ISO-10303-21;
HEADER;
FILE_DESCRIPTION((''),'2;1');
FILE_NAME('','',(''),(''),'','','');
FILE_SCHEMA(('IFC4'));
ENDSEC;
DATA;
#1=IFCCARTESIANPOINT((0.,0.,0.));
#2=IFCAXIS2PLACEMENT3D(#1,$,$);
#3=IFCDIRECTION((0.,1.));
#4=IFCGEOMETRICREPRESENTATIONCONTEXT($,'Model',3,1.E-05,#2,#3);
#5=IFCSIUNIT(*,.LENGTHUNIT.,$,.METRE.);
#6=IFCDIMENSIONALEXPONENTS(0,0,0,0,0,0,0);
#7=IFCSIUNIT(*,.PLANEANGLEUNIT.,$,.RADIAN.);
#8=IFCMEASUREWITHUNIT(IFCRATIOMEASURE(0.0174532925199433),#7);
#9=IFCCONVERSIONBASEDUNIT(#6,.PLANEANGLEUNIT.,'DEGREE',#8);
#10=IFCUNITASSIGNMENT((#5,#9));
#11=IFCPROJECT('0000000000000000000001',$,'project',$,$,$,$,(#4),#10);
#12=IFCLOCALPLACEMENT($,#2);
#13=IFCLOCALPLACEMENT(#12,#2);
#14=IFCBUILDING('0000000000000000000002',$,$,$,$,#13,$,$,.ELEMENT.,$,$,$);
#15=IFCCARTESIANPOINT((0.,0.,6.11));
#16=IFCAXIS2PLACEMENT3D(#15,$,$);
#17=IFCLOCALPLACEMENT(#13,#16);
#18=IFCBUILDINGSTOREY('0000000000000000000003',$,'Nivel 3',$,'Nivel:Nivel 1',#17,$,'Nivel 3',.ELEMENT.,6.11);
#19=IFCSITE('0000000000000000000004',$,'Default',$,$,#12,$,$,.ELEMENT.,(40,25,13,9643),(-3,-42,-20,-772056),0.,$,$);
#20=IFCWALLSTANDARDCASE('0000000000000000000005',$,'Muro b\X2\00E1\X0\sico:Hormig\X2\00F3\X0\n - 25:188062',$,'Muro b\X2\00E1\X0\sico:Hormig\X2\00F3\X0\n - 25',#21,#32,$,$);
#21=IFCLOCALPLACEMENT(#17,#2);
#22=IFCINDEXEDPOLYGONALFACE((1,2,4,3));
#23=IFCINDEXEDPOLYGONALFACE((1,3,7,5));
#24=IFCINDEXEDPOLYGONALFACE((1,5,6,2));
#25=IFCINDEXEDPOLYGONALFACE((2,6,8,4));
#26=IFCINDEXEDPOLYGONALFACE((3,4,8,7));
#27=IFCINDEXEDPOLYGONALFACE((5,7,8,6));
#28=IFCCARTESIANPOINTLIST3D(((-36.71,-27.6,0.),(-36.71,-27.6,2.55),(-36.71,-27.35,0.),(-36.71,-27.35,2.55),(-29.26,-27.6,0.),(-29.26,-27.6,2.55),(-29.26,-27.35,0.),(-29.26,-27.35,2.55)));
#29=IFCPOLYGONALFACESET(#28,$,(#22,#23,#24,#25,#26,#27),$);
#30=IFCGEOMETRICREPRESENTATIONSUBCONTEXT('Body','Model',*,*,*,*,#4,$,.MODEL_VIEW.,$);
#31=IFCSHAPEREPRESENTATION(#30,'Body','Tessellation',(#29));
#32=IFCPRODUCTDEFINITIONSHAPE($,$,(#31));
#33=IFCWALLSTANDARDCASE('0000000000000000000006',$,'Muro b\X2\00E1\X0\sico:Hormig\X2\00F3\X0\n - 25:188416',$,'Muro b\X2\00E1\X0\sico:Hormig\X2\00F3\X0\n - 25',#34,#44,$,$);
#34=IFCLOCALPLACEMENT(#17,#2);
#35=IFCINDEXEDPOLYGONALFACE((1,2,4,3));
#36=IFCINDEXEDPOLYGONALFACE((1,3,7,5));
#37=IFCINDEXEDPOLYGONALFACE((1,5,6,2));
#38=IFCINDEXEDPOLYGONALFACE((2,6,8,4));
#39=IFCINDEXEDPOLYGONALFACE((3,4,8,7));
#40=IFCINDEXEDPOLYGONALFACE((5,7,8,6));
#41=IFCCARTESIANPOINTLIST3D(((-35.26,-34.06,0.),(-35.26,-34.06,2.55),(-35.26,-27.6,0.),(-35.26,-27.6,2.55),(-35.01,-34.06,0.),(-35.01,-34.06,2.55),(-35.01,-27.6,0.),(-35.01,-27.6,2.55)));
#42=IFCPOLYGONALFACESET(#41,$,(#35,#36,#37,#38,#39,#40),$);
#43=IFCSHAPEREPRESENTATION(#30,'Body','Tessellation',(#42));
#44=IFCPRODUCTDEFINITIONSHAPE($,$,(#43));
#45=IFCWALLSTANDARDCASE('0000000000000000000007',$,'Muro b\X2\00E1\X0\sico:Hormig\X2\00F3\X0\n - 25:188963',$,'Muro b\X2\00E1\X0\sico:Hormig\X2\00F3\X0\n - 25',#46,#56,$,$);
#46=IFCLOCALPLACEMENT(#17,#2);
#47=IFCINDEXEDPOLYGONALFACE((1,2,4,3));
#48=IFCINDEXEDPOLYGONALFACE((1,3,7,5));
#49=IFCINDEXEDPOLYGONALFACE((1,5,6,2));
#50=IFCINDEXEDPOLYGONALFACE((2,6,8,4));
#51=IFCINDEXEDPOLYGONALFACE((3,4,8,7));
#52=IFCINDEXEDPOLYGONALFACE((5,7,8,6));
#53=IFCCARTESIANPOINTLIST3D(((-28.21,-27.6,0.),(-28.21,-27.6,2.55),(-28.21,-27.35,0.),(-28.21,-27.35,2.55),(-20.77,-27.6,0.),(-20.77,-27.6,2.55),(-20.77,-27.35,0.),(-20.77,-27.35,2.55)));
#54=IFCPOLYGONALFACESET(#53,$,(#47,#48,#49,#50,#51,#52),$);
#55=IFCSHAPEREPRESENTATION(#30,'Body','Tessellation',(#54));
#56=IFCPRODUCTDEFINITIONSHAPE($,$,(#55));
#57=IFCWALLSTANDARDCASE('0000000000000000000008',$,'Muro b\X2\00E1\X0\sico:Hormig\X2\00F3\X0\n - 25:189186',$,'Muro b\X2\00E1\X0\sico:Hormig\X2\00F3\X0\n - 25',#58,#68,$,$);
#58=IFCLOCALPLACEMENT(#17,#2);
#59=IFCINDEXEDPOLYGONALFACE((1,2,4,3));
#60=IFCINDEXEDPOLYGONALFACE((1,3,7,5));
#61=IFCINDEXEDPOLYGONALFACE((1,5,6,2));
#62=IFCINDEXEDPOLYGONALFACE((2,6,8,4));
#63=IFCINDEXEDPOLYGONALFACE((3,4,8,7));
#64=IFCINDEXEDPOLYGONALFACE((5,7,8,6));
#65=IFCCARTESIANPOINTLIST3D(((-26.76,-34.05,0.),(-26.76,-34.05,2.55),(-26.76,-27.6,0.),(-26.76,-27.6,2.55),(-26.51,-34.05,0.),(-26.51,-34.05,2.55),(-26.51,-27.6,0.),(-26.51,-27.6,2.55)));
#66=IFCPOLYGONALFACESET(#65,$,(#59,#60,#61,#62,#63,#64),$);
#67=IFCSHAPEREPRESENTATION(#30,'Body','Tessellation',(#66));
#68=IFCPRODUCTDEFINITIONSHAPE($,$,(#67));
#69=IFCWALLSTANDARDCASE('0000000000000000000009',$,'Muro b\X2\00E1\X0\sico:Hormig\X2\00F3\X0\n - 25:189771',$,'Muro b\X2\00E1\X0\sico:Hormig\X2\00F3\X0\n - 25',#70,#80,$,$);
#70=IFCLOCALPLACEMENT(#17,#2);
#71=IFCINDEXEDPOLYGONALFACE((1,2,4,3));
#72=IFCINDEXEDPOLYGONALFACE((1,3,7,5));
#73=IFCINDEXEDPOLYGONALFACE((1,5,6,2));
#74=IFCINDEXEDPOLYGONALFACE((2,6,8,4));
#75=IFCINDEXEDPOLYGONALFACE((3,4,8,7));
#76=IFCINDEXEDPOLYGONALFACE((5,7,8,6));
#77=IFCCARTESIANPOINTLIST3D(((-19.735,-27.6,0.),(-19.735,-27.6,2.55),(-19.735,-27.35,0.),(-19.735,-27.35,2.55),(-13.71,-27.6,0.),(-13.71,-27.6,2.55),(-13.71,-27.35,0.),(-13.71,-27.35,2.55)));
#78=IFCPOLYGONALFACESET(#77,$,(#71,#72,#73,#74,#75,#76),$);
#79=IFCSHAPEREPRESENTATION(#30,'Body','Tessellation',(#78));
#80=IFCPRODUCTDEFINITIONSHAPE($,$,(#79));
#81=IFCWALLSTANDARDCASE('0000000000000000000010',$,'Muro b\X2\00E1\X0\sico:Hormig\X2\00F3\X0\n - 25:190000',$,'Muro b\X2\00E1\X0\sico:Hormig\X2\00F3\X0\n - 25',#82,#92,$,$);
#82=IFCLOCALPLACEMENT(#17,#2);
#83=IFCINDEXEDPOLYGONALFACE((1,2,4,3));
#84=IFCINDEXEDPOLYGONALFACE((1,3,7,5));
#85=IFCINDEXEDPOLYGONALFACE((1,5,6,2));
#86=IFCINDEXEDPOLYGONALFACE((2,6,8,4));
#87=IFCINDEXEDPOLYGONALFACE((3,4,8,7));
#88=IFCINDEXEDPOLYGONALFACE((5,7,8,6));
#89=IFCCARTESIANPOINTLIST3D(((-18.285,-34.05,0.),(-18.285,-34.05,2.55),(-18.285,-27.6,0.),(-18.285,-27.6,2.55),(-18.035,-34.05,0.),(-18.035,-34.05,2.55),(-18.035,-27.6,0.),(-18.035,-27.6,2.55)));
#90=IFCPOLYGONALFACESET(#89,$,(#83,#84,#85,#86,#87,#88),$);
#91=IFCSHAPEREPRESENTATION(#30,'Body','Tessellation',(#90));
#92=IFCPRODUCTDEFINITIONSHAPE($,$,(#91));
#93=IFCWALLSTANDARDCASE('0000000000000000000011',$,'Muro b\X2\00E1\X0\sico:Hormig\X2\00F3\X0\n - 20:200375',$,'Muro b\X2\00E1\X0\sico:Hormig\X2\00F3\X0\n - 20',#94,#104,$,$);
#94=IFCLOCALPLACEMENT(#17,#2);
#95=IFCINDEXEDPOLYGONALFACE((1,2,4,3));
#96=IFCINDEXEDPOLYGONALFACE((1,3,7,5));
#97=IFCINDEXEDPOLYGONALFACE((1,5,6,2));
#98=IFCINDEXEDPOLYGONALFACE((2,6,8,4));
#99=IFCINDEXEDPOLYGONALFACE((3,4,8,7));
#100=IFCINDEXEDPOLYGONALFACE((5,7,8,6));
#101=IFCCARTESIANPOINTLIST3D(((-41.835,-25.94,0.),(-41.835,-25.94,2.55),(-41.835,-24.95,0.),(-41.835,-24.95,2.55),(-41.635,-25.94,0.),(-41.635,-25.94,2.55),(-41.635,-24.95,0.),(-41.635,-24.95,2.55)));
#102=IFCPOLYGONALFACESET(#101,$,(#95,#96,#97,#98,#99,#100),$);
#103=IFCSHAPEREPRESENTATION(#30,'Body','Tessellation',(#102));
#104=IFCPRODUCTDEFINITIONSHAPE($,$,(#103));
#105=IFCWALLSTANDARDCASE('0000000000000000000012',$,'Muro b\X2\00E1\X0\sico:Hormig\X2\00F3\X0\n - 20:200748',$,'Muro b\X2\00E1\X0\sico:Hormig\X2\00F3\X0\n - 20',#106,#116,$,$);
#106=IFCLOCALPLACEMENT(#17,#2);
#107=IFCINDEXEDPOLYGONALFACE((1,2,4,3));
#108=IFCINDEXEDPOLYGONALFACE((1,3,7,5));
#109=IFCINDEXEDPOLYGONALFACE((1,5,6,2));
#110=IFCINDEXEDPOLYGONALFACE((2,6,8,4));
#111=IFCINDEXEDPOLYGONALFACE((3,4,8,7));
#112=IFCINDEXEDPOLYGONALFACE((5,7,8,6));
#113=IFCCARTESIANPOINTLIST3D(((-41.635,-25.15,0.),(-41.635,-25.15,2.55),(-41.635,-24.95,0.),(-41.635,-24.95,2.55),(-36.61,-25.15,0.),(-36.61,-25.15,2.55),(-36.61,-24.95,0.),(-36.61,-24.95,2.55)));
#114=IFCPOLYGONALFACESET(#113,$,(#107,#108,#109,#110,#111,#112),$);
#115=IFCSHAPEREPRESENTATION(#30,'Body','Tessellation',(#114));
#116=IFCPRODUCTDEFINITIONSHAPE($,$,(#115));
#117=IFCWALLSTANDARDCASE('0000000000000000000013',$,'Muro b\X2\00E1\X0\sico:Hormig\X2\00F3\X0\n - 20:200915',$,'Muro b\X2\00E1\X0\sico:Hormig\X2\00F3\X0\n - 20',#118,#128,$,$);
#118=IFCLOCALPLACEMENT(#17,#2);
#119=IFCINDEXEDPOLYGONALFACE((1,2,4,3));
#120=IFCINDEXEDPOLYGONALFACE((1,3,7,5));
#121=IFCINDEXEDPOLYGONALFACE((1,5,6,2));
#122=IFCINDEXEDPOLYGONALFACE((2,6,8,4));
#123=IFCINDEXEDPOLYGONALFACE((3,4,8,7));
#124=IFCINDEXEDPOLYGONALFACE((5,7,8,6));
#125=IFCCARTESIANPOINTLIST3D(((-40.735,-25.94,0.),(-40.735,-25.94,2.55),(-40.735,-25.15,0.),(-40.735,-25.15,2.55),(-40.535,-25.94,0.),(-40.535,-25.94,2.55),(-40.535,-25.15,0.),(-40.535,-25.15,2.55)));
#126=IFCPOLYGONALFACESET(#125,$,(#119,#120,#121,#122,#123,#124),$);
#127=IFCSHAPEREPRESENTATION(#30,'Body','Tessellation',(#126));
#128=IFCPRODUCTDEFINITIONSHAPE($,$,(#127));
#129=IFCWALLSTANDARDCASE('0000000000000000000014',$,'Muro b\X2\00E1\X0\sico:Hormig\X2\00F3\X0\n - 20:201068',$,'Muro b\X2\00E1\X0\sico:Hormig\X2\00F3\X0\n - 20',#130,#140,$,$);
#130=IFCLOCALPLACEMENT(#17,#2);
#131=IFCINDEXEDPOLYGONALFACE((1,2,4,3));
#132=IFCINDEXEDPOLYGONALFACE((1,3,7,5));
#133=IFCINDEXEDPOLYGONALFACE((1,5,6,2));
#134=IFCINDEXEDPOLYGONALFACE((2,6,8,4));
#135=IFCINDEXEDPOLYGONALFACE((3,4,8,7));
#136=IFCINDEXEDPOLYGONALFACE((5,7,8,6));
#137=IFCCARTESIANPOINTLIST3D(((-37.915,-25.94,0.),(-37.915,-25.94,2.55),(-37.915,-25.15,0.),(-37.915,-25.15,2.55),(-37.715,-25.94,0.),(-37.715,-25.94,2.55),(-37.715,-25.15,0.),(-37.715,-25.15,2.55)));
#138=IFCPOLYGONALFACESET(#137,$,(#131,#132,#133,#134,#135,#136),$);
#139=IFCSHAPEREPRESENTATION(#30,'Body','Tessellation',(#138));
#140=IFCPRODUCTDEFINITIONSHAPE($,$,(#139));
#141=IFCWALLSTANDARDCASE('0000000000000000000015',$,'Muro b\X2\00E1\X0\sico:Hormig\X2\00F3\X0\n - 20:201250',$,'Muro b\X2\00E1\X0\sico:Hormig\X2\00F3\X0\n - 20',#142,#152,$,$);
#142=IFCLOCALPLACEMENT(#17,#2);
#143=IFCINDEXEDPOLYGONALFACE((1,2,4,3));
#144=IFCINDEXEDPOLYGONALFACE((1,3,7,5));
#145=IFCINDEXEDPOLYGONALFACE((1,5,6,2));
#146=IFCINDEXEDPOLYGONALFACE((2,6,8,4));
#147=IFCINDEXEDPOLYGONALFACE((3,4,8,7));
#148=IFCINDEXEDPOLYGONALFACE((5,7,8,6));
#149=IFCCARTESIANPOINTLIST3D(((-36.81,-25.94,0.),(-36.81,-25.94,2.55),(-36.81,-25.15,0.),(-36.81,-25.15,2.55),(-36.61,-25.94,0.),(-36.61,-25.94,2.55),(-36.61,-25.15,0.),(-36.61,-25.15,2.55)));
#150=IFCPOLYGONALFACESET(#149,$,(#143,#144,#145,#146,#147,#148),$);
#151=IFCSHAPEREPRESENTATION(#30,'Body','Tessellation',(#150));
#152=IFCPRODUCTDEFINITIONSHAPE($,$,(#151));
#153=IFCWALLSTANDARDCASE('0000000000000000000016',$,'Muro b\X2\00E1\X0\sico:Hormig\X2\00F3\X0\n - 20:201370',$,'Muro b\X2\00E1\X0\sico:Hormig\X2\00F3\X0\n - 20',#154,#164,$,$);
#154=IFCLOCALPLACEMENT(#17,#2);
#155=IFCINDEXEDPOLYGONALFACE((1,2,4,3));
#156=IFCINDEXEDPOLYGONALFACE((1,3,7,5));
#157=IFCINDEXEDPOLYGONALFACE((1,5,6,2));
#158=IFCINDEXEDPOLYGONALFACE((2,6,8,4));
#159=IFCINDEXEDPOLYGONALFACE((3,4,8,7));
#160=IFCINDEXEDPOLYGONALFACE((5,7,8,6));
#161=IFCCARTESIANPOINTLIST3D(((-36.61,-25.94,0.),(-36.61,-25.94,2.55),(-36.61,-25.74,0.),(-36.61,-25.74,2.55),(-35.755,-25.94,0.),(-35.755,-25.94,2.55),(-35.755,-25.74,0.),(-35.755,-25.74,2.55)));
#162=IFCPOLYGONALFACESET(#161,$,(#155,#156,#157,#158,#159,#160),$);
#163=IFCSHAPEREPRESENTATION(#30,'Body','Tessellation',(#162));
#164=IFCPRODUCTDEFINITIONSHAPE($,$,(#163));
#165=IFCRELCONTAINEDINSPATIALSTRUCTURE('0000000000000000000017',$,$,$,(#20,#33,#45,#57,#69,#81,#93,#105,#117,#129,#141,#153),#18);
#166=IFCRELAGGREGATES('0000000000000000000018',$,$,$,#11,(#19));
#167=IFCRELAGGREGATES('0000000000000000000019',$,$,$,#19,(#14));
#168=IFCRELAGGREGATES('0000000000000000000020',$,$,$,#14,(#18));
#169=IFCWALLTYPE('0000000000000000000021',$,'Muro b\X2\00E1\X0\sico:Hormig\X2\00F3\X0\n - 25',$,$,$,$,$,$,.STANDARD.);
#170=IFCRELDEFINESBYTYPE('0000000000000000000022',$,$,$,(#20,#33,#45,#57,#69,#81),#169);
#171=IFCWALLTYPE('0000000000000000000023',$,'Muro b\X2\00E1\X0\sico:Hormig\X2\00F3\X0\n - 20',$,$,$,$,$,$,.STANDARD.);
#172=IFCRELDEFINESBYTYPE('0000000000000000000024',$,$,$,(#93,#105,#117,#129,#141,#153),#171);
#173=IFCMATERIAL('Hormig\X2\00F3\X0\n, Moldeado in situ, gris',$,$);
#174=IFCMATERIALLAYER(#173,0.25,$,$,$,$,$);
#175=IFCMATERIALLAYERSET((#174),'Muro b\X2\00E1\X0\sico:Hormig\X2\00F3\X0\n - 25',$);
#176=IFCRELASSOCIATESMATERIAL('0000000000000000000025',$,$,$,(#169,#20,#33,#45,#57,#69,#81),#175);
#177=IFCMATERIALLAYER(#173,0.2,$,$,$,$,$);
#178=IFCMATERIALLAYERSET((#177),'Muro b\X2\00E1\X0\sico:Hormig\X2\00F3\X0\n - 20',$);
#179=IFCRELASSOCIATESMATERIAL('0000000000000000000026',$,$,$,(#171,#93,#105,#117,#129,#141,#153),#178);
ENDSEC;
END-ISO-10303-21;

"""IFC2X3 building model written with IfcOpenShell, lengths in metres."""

from ifc_helpers import new_model, entity, si_unit, converted_unit, direction, frame, frame_2d, origin, place, context, subcontext, project, spatial, rectangle, extrude, material, layer, layer_set, layer_usage, type_object, element, save


model = new_model("IFC2X3")

# Units and contexts
model_context = context("Model", 3, precision=1e-05, world=origin(), true_north=direction((0.0, 1.0)))
body_context = subcontext(model_context, "Body", "Model", "MODEL_VIEW")
ifc_project = project(units=[si_unit("LENGTHUNIT", "METRE"), converted_unit("PLANEANGLEUNIT", "DEGREE", entity("IfcRatioMeasure", 0.0174532925199433), si_unit("PLANEANGLEUNIT", "RADIAN"), dimensions=[0, 0, 0, 0, 0, 0, 0])], contexts=[model_context])

# Site, building, storey
site_placement = place(None, origin())
site = spatial("IfcSite", under=ifc_project, at=site_placement, Name="Default", CompositionType="ELEMENT", RefLatitude=(40, 25, 13, 9643), RefLongitude=(-3, -42, -20, -772056), RefElevation=0.0)
building_placement = place(site_placement, origin())
building = spatial("IfcBuilding", under=site, at=building_placement, CompositionType="ELEMENT")
storey_placement = place(building_placement, frame((0.0, 0.0, 6.11)))
storey = spatial("IfcBuildingStorey", under=building, at=storey_placement, Name="Nivel 3", ObjectType="Nivel:Nivel 1", LongName="Nivel 3", CompositionType="ELEMENT", Elevation=6.11)

# Walls
ifc_material = material(Name="Hormigón, Moldeado in situ, gris")
ifc_layer_1 = layer(ifc_material, 0.25)
ifc_layer_set_1 = layer_set([ifc_layer_1], Name="Muro básico:Hormigón - 25")
wall_type_1 = type_object("IfcWallType", Name="Muro básico:Hormigón - 25", PredefinedType="STANDARD", material=ifc_layer_set_1)
ifc_layer_usage_1 = layer_usage(ifc_layer_set_1, "AXIS2", "NEGATIVE", 0.125)
wall_1_placement = place(storey_placement, frame((-36.71, -27.475, 0.0)))
element("IfcWallStandardCase", 1, at=wall_1_placement, inside=storey, type_object=wall_type_1, material=ifc_layer_usage_1, Name="Muro básico:Hormigón - 25:188062", ObjectType="Muro básico:Hormigón - 25", context=body_context, shape_type="SweptSolid", body=[
    extrude(rectangle(XDim=7.45, YDim=0.25, at=frame_2d((3.725, 0.0), x_axis=(-1.0, 0.0))), origin(), (0.0, 0.0, 1.0), 2.55),
])
ifc_layer_usage_2 = layer_usage(ifc_layer_set_1, "AXIS2", "NEGATIVE", 0.125)
wall_2_placement = place(storey_placement, frame((-35.135, -27.6, 0.0), z_axis=(0.0, 0.0, 1.0), x_axis=(0.0, -1.0, 0.0)))
element("IfcWallStandardCase", 2, at=wall_2_placement, inside=storey, type_object=wall_type_1, material=ifc_layer_usage_2, Name="Muro básico:Hormigón - 25:188416", ObjectType="Muro básico:Hormigón - 25", context=body_context, shape_type="SweptSolid", body=[
    extrude(rectangle(XDim=6.46, YDim=0.25, at=frame_2d((3.23, 0.0), x_axis=(-1.0, 0.0))), origin(), (0.0, 0.0, 1.0), 2.55),
])
ifc_layer_usage_3 = layer_usage(ifc_layer_set_1, "AXIS2", "NEGATIVE", 0.125)
wall_3_placement = place(storey_placement, frame((-28.21, -27.475, 0.0)))
element("IfcWallStandardCase", 3, at=wall_3_placement, inside=storey, type_object=wall_type_1, material=ifc_layer_usage_3, Name="Muro básico:Hormigón - 25:188963", ObjectType="Muro básico:Hormigón - 25", context=body_context, shape_type="SweptSolid", body=[
    extrude(rectangle(XDim=7.44, YDim=0.25, at=frame_2d((3.72, 0.0), x_axis=(-1.0, 0.0))), origin(), (0.0, 0.0, 1.0), 2.55),
])
ifc_layer_usage_4 = layer_usage(ifc_layer_set_1, "AXIS2", "NEGATIVE", 0.125)
wall_4_placement = place(storey_placement, frame((-26.635, -27.6, 0.0), z_axis=(0.0, 0.0, 1.0), x_axis=(0.0, -1.0, 0.0)))
element("IfcWallStandardCase", 4, at=wall_4_placement, inside=storey, type_object=wall_type_1, material=ifc_layer_usage_4, Name="Muro básico:Hormigón - 25:189186", ObjectType="Muro básico:Hormigón - 25", context=body_context, shape_type="SweptSolid", body=[
    extrude(rectangle(XDim=6.45, YDim=0.25, at=frame_2d((3.225, 0.0), x_axis=(-1.0, 0.0))), origin(), (0.0, 0.0, 1.0), 2.55),
])
ifc_layer_usage_5 = layer_usage(ifc_layer_set_1, "AXIS2", "NEGATIVE", 0.125)
wall_5_placement = place(storey_placement, frame((-19.735, -27.475, 0.0)))
element("IfcWallStandardCase", 5, at=wall_5_placement, inside=storey, type_object=wall_type_1, material=ifc_layer_usage_5, Name="Muro básico:Hormigón - 25:189771", ObjectType="Muro básico:Hormigón - 25", context=body_context, shape_type="SweptSolid", body=[
    extrude(rectangle(XDim=6.025, YDim=0.25, at=frame_2d((3.0125, 0.0), x_axis=(-1.0, 0.0))), origin(), (0.0, 0.0, 1.0), 2.55),
])
ifc_layer_usage_6 = layer_usage(ifc_layer_set_1, "AXIS2", "NEGATIVE", 0.125)
wall_6_placement = place(storey_placement, frame((-18.16, -27.6, 0.0), z_axis=(0.0, 0.0, 1.0), x_axis=(0.0, -1.0, 0.0)))
element("IfcWallStandardCase", 6, at=wall_6_placement, inside=storey, type_object=wall_type_1, material=ifc_layer_usage_6, Name="Muro básico:Hormigón - 25:190000", ObjectType="Muro básico:Hormigón - 25", context=body_context, shape_type="SweptSolid", body=[
    extrude(rectangle(XDim=6.45, YDim=0.25, at=frame_2d((3.225, 0.0), x_axis=(-1.0, 0.0))), origin(), (0.0, 0.0, 1.0), 2.55),
])
ifc_layer_2 = layer(ifc_material, 0.2)
ifc_layer_set_2 = layer_set([ifc_layer_2], Name="Muro básico:Hormigón - 20")
ifc_layer_usage_7 = layer_usage(ifc_layer_set_2, "AXIS2", "NEGATIVE", 0.1)
wall_type_2 = type_object("IfcWallType", Name="Muro básico:Hormigón - 20", PredefinedType="STANDARD", material=ifc_layer_set_2)
wall_7_placement = place(storey_placement, frame((-41.735, -25.94, 0.0), z_axis=(0.0, 0.0, 1.0), x_axis=(0.0, 1.0, 0.0)))
element("IfcWallStandardCase", 7, at=wall_7_placement, inside=storey, type_object=wall_type_2, material=ifc_layer_usage_7, Name="Muro básico:Hormigón - 20:200375", ObjectType="Muro básico:Hormigón - 20", context=body_context, shape_type="SweptSolid", body=[
    extrude(rectangle(XDim=0.99, YDim=0.2, at=frame_2d((0.495, 0.0), x_axis=(-1.0, 0.0))), origin(), (0.0, 0.0, 1.0), 2.55),
])
ifc_layer_usage_8 = layer_usage(ifc_layer_set_2, "AXIS2", "NEGATIVE", 0.1)
wall_8_placement = place(storey_placement, frame((-36.61, -25.05, 0.0), z_axis=(0.0, 0.0, 1.0), x_axis=(-1.0, 0.0, 0.0)))
element("IfcWallStandardCase", 8, at=wall_8_placement, inside=storey, type_object=wall_type_2, material=ifc_layer_usage_8, Name="Muro básico:Hormigón - 20:200748", ObjectType="Muro básico:Hormigón - 20", context=body_context, shape_type="SweptSolid", body=[
    extrude(rectangle(XDim=5.025, YDim=0.2, at=frame_2d((2.5125, 0.0), x_axis=(-1.0, 0.0))), origin(), (0.0, 0.0, 1.0), 2.55),
])
ifc_layer_usage_9 = layer_usage(ifc_layer_set_2, "AXIS2", "NEGATIVE", 0.1)
wall_9_placement = place(storey_placement, frame((-40.635, -25.94, 0.0), z_axis=(0.0, 0.0, 1.0), x_axis=(0.0, 1.0, 0.0)))
element("IfcWallStandardCase", 9, at=wall_9_placement, inside=storey, type_object=wall_type_2, material=ifc_layer_usage_9, Name="Muro básico:Hormigón - 20:200915", ObjectType="Muro básico:Hormigón - 20", context=body_context, shape_type="SweptSolid", body=[
    extrude(rectangle(XDim=0.79, YDim=0.2, at=frame_2d((0.395, 0.0), x_axis=(-1.0, 0.0))), origin(), (0.0, 0.0, 1.0), 2.55),
])
ifc_layer_usage_10 = layer_usage(ifc_layer_set_2, "AXIS2", "NEGATIVE", 0.1)
wall_10_placement = place(storey_placement, frame((-37.815, -25.94, 0.0), z_axis=(0.0, 0.0, 1.0), x_axis=(0.0, 1.0, 0.0)))
element("IfcWallStandardCase", 10, at=wall_10_placement, inside=storey, type_object=wall_type_2, material=ifc_layer_usage_10, Name="Muro básico:Hormigón - 20:201068", ObjectType="Muro básico:Hormigón - 20", context=body_context, shape_type="SweptSolid", body=[
    extrude(rectangle(XDim=0.79, YDim=0.2, at=frame_2d((0.395, 0.0), x_axis=(-1.0, 0.0))), origin(), (0.0, 0.0, 1.0), 2.55),
])
ifc_layer_usage_11 = layer_usage(ifc_layer_set_2, "AXIS2", "NEGATIVE", 0.1)
wall_11_placement = place(storey_placement, frame((-36.71, -25.15, 0.0), z_axis=(0.0, 0.0, 1.0), x_axis=(0.0, -1.0, 0.0)))
element("IfcWallStandardCase", 11, at=wall_11_placement, inside=storey, type_object=wall_type_2, material=ifc_layer_usage_11, Name="Muro básico:Hormigón - 20:201250", ObjectType="Muro básico:Hormigón - 20", context=body_context, shape_type="SweptSolid", body=[
    extrude(rectangle(XDim=0.79, YDim=0.2, at=frame_2d((0.395, 0.0), x_axis=(-1.0, 0.0))), origin(), (0.0, 0.0, 1.0), 2.55),
])
ifc_layer_usage_12 = layer_usage(ifc_layer_set_2, "AXIS2", "NEGATIVE", 0.1)
wall_12_placement = place(storey_placement, frame((-35.755, -25.84, 0.0), z_axis=(0.0, 0.0, 1.0), x_axis=(-1.0, 0.0, 0.0)))
element("IfcWallStandardCase", 12, at=wall_12_placement, inside=storey, type_object=wall_type_2, material=ifc_layer_usage_12, Name="Muro básico:Hormigón - 20:201370", ObjectType="Muro básico:Hormigón - 20", context=body_context, shape_type="SweptSolid", body=[
    extrude(rectangle(XDim=0.855, YDim=0.2, at=frame_2d((0.4275, 0.0), x_axis=(-1.0, 0.0))), origin(), (0.0, 0.0, 1.0), 2.55),
])

save(model, "model.ifc")
